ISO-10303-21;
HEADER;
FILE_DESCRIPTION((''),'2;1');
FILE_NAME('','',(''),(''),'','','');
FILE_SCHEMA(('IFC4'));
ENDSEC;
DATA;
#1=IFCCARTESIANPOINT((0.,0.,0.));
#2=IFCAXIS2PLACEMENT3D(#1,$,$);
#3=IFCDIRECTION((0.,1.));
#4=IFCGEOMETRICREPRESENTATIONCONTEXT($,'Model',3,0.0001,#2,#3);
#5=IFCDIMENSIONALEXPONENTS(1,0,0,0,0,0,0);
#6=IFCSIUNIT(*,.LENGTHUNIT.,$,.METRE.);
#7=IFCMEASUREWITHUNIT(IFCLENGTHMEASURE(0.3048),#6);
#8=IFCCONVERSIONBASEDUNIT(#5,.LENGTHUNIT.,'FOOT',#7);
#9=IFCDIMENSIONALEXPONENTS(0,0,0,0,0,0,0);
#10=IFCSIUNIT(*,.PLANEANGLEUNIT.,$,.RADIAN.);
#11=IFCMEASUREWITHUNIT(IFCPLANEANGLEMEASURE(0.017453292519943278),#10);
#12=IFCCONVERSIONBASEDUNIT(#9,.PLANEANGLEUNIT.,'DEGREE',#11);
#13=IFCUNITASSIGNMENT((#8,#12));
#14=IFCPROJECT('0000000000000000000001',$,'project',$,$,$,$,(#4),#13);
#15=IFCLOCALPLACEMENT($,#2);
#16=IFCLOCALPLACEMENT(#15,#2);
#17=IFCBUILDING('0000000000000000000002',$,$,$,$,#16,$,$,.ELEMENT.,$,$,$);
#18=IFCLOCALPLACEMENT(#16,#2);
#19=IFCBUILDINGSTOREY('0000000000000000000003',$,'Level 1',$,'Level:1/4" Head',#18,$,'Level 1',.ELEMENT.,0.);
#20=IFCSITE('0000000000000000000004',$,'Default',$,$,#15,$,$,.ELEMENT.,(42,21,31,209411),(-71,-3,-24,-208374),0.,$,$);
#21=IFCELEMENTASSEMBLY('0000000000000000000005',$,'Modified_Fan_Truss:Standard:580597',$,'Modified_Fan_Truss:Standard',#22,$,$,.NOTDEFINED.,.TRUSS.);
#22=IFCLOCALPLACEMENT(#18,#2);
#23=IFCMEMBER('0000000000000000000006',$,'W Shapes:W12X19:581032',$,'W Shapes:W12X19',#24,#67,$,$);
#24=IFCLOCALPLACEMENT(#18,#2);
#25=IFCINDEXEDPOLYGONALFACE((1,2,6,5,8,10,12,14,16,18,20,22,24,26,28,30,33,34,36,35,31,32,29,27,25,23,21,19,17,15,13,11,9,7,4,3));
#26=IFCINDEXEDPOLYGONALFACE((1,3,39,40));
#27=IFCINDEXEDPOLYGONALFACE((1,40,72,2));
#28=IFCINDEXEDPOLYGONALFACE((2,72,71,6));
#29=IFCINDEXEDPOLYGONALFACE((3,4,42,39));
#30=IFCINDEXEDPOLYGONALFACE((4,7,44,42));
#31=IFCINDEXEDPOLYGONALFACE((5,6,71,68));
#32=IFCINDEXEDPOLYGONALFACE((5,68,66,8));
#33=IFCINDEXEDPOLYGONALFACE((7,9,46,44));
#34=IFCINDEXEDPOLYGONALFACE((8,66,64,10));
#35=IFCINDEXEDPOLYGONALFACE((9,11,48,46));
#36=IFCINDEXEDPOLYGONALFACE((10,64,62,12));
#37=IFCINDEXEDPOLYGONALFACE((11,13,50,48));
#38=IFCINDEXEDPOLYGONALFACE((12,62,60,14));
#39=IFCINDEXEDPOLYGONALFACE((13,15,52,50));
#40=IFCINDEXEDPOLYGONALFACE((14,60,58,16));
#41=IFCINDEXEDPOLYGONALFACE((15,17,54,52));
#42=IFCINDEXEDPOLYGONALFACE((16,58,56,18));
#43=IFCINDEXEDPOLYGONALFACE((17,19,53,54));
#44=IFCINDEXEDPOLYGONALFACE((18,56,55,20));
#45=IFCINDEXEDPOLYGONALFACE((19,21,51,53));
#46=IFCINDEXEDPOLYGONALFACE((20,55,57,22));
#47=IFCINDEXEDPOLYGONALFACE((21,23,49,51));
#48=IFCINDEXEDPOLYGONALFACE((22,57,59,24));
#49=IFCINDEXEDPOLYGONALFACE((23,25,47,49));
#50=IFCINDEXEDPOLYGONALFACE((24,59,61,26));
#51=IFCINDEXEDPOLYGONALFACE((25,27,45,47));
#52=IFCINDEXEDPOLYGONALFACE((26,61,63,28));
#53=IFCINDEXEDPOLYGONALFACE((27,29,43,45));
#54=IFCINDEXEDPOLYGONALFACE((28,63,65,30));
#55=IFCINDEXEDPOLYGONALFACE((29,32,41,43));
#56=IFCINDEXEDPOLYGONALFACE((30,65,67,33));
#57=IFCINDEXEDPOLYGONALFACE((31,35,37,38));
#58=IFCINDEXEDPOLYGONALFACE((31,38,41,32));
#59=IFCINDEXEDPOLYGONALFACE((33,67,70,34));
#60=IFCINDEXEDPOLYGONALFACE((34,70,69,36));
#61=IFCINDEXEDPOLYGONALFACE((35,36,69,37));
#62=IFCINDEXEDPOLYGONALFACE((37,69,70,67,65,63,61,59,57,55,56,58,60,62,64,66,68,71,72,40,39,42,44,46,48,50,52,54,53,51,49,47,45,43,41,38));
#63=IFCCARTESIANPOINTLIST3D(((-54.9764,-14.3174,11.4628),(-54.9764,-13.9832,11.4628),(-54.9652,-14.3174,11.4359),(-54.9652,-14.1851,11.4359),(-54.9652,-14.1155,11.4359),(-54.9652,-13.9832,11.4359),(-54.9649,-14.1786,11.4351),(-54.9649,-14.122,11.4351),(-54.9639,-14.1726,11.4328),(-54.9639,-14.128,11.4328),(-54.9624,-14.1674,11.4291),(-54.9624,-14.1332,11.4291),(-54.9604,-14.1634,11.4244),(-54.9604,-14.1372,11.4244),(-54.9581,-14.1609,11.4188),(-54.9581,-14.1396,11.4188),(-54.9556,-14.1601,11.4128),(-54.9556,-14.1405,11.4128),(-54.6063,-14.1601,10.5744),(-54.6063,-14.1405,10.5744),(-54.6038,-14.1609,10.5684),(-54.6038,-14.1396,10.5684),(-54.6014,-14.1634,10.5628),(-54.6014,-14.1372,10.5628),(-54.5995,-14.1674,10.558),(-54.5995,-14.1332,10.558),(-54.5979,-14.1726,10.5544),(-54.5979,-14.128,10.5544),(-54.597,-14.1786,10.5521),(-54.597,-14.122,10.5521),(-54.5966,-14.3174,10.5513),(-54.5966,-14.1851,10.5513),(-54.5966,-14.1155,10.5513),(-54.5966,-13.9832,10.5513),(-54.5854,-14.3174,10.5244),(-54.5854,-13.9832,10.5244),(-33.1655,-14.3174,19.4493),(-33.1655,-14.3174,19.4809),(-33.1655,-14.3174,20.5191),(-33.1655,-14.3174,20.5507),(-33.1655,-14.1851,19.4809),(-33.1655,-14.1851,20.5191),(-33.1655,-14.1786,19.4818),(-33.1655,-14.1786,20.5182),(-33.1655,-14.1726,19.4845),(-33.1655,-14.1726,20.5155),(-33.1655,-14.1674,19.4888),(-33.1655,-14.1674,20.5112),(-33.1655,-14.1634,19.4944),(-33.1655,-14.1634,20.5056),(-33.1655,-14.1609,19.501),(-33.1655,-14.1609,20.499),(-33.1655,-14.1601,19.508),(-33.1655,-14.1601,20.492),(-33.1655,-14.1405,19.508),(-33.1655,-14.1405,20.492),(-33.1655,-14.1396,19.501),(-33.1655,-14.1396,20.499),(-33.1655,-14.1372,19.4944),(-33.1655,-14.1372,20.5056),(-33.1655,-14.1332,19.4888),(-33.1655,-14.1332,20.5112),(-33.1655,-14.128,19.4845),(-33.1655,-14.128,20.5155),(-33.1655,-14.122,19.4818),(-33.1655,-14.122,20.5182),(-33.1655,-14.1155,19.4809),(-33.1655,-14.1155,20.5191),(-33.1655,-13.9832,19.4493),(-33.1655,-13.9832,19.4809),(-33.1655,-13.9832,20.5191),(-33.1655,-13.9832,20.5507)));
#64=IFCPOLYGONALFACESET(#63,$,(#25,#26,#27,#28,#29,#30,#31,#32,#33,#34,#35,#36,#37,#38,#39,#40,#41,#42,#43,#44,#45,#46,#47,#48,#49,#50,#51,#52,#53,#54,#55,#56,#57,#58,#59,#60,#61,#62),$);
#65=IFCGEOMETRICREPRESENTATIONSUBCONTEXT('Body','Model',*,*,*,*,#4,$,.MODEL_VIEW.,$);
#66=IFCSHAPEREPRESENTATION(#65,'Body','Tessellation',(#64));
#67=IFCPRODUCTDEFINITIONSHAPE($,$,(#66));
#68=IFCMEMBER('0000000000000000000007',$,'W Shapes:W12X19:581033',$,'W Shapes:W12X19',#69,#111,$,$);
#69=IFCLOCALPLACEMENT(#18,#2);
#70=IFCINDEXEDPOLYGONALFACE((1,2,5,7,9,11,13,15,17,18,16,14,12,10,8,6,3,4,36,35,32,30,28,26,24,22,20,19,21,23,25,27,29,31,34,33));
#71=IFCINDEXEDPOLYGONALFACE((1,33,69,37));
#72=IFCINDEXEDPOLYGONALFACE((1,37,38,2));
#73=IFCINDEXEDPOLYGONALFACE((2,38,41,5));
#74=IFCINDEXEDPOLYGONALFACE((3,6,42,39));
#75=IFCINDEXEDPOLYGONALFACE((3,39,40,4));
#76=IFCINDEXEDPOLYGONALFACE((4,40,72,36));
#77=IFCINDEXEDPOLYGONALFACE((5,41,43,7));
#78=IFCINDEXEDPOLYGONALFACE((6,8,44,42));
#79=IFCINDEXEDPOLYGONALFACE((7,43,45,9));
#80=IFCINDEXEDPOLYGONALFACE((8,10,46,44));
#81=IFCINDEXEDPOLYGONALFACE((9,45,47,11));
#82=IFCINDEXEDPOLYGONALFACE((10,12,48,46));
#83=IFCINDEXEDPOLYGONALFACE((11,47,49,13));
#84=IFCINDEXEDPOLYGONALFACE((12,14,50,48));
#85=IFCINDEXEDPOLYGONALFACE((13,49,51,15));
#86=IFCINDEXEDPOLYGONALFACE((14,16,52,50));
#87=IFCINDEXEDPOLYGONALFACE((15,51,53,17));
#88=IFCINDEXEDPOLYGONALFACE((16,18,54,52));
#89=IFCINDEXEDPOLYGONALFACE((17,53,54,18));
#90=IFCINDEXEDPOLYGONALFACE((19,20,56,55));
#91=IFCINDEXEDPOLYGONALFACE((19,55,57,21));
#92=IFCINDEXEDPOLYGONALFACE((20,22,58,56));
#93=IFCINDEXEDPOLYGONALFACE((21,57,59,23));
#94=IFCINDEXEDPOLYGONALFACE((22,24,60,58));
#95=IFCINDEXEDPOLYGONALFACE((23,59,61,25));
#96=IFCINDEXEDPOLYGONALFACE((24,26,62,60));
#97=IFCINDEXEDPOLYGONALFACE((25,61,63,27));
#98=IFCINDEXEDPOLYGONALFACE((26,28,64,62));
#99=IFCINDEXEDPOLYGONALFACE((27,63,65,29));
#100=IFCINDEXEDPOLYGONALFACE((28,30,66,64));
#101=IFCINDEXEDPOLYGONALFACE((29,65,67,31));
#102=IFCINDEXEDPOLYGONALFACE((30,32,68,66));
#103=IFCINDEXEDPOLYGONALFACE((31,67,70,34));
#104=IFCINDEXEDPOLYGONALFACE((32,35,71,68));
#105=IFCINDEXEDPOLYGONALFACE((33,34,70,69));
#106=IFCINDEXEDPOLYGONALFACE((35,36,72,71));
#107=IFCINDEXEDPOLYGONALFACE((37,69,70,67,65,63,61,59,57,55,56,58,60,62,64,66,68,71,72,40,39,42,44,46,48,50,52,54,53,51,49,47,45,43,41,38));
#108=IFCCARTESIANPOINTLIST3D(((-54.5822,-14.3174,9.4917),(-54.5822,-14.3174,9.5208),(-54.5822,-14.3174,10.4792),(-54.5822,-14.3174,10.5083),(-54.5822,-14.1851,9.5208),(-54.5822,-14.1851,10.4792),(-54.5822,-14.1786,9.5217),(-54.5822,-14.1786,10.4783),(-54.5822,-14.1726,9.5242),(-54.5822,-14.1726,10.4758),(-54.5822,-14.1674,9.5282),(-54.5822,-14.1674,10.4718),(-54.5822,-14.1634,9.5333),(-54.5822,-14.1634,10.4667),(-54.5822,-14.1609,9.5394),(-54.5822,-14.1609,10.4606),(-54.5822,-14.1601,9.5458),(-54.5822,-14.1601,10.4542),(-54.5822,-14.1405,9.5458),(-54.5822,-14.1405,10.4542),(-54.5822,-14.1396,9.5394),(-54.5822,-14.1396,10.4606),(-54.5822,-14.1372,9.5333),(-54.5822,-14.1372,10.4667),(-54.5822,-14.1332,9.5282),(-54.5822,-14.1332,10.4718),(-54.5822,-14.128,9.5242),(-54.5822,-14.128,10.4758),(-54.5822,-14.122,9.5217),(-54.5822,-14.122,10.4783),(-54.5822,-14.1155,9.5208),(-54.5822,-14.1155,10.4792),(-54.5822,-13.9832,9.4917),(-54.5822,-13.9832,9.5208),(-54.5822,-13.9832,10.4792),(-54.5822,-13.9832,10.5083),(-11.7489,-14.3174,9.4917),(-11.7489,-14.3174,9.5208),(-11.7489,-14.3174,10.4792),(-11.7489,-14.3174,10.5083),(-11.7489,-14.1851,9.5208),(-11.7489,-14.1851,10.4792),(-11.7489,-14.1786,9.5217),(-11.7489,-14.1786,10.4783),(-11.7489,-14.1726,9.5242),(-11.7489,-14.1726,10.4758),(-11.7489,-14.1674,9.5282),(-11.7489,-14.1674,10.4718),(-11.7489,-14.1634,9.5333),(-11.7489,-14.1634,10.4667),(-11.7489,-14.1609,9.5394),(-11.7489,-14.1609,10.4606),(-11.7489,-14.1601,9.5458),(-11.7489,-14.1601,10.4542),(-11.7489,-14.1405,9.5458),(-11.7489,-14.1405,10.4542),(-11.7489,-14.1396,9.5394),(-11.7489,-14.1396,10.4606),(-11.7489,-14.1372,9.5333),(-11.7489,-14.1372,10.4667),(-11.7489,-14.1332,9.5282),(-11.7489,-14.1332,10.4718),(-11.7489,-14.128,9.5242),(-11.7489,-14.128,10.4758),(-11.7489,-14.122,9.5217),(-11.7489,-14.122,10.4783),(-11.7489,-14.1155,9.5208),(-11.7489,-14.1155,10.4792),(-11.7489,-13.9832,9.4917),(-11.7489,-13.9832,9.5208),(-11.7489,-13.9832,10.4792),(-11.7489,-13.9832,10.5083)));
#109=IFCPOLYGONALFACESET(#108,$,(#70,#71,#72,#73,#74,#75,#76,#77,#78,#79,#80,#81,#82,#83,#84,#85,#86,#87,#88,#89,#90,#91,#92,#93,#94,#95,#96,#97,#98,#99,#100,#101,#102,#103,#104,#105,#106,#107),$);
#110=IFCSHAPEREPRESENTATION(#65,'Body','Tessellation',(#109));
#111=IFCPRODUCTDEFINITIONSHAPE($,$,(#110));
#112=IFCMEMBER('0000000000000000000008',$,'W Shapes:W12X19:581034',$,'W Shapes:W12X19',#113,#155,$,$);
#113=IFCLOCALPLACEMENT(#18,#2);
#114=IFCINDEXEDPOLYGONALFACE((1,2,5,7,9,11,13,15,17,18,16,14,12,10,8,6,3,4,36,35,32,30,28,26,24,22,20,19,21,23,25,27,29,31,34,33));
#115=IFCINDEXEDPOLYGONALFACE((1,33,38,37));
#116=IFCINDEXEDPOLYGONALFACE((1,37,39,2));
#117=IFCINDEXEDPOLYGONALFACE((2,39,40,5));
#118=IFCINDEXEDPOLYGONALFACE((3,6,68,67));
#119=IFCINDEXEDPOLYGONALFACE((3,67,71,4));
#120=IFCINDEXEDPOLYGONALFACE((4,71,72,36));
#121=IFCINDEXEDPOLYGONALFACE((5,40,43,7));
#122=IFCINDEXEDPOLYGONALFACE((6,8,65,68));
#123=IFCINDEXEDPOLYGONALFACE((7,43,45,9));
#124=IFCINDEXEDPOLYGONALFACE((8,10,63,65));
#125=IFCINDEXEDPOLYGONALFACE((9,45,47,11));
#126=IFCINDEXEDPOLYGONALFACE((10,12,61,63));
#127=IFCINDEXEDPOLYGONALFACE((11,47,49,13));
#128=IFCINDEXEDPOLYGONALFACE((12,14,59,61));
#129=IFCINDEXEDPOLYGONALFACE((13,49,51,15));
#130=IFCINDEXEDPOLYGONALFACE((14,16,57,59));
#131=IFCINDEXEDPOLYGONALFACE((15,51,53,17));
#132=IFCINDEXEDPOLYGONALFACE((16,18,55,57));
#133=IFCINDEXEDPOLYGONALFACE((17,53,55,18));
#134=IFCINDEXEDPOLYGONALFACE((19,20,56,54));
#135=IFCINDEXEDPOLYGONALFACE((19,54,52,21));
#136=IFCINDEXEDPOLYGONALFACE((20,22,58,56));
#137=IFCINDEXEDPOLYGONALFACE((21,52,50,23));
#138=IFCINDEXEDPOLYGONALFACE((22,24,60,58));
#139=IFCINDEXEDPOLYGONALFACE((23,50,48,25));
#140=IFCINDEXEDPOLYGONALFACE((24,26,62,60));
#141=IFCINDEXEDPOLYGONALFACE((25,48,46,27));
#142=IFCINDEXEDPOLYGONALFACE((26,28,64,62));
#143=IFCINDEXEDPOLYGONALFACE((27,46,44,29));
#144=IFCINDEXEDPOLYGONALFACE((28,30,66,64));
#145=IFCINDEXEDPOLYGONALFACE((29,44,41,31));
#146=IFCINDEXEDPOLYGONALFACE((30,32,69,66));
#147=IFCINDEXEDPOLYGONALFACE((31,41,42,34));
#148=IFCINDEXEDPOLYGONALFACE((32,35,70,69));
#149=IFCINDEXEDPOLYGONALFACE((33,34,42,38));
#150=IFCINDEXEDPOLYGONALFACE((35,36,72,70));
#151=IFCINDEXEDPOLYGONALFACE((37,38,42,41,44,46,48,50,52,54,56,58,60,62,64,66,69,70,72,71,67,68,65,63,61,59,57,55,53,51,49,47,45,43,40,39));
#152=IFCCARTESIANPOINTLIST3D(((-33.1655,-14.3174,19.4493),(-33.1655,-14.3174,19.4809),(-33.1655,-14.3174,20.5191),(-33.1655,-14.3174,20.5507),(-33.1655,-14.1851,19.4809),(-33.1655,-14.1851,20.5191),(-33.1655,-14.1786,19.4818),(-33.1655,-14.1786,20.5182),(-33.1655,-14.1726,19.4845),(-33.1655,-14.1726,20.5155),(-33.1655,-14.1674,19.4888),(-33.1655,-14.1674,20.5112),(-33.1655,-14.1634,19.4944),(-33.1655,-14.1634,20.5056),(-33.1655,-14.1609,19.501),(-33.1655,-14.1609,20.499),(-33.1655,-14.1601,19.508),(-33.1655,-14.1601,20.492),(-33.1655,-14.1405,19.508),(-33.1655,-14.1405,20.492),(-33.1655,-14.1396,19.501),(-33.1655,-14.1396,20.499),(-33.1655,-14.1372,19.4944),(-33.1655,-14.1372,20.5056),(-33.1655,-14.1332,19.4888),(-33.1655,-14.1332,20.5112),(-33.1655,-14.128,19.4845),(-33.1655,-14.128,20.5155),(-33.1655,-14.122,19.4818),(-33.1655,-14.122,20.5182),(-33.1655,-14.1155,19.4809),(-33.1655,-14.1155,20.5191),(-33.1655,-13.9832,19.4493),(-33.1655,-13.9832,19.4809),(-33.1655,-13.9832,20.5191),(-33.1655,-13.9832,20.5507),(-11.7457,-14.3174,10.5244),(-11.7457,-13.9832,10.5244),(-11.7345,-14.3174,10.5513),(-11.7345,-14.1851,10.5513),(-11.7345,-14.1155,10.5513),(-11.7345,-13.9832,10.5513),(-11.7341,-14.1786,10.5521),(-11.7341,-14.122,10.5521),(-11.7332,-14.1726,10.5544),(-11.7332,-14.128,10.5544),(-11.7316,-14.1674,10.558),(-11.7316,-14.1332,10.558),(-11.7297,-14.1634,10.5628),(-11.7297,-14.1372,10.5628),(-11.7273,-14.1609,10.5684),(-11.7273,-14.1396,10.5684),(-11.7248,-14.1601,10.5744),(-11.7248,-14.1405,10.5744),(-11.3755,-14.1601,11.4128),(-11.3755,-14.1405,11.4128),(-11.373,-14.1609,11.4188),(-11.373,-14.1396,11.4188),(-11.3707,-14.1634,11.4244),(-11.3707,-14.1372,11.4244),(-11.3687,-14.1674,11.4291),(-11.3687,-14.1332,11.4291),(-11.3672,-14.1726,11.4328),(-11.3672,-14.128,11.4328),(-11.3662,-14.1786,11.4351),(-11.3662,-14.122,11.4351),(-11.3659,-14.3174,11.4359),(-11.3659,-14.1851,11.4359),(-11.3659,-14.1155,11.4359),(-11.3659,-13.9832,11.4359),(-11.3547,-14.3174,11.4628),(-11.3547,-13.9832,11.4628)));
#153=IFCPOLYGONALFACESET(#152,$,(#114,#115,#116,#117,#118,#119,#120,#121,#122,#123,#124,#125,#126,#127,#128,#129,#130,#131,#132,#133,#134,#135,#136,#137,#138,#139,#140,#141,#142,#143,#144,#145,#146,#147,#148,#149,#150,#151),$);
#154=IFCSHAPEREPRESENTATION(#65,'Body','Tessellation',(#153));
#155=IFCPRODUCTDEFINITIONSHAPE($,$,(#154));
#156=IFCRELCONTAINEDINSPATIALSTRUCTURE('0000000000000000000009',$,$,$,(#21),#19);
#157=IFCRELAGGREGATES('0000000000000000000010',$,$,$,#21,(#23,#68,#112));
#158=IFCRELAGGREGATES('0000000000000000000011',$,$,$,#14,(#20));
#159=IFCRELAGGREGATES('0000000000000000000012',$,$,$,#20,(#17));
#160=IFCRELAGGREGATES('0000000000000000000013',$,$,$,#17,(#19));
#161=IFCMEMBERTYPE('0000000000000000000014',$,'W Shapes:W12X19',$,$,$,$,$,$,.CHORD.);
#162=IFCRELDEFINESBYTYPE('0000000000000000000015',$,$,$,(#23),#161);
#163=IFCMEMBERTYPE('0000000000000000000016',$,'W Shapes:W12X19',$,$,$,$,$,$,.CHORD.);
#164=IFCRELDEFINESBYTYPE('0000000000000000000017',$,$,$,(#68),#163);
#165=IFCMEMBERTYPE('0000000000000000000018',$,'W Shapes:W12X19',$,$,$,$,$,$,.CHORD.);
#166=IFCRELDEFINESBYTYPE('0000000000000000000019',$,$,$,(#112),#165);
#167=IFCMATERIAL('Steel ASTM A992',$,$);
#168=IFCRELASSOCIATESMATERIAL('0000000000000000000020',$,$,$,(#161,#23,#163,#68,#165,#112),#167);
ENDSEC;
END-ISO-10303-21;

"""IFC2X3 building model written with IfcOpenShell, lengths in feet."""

from ifc_helpers import new_model, entity, si_unit, converted_unit, direction, frame, frame_2d, origin, place, context, subcontext, project, spatial, polyline, circle_curve, parameter, trimmed, segment, composite_curve, i_section, outline, extrude, clip, halfspace, source, transform, mapped, material, type_object, type_shapes, element, aggregate, save


model = new_model("IFC2X3")

# Units and contexts
model_context = context("Model", 3, precision=0.0001, world=origin(), true_north=direction((0.0, 1.0)))
body_context = subcontext(model_context, "Body", "Model", "MODEL_VIEW")
ifc_project = project(units=[converted_unit("LENGTHUNIT", "FOOT", entity("IfcLengthMeasure", 0.3048), si_unit("LENGTHUNIT", "METRE"), dimensions=[1, 0, 0, 0, 0, 0, 0]), converted_unit("PLANEANGLEUNIT", "DEGREE", entity("IfcPlaneAngleMeasure", 0.017453292519943278), si_unit("PLANEANGLEUNIT", "RADIAN"), dimensions=[0, 0, 0, 0, 0, 0, 0])], contexts=[model_context])

# Site, building, storey
site_placement = place(None, origin())
site = spatial("IfcSite", under=ifc_project, at=site_placement, Name="Default", CompositionType="ELEMENT", RefLatitude=(42, 21, 31, 209411), RefLongitude=(-71, -3, -24, -208374), RefElevation=0.0)
building_placement = place(site_placement, origin())
building = spatial("IfcBuilding", under=site, at=building_placement, CompositionType="ELEMENT")
storey_placement = place(building_placement, origin())
storey = spatial("IfcBuildingStorey", under=building, at=storey_placement, Name="Level 1", ObjectType="Level:1/4\" Head", LongName="Level 1", CompositionType="ELEMENT", Elevation=0.0)

# Element assembly, members
assembly_placement = place(storey_placement, origin())
assembly = element("IfcElementAssembly", 1, at=assembly_placement, inside=storey, Name="Modified_Fan_Truss:Standard:580597", ObjectType="Modified_Fan_Truss:Standard", AssemblyPlace="NOTDEFINED", PredefinedType="TRUSS")
ifc_material = material(Name="Steel ASTM A992")
member_type_1 = type_object("IfcMemberType", Name="W Shapes:W12X19", PredefinedType="CHORD", material=ifc_material)
shared_shape_1 = source(origin(), body_context, "Body", "Clipping", [
    clip(extrude(i_section(OverallWidth=0.3342, OverallDepth=1.0167, WebThickness=0.0196, FlangeThickness=0.0292, FilletRadius=0.025, at=frame_2d((0.0, 0.0), x_axis=(1.0, 0.0))), frame((-54.7809, -14.1503, 10.9936), z_axis=(0.923077, 0.0, 0.384615), x_axis=(0.0, -1.0, 0.0)), (0.0, 0.0, 1.0), 23.6285), halfspace(frame((-33.1655, -14.1503, 20.5507), z_axis=(1.0, 0.0, 0.0), x_axis=(0.0, -1.0, 0.0)), False)),
])
type_shapes(member_type_1, [shared_shape_1])
member_1_placement = place(assembly_placement, origin())
member_1 = element("IfcMember", 2, at=member_1_placement, type_object=member_type_1, material=ifc_material, Name="W Shapes:W12X19:581032", ObjectType="W Shapes:W12X19", context=body_context, shape_type="MappedRepresentation", body=[
    mapped(shared_shape_1, transform((0.0, 0.0, 0.0), scale=1.0)),
])
member_type_2 = type_object("IfcMemberType", Name="W Shapes:W12X19", PredefinedType="CHORD", material=ifc_material)
shared_shape_2 = source(origin(), body_context, "Body", "SweptSolid", [
    extrude(outline(composite_curve([segment(polyline([(-0.1671, -0.4792), (-0.1671, -0.5083)]), True, "CONTINUOUS"), segment(polyline([(-0.1671, -0.5083), (0.1671, -0.5083)]), True, "CONTINUOUS"), segment(polyline([(0.1671, -0.5083), (0.1671, -0.4792)]), True, "CONTINUOUS"), segment(polyline([(0.1671, -0.4792), (0.0348, -0.4792)]), True, "CONTINUOUS"), segment(trimmed(circle_curve(frame_2d((0.0348, -0.4542), x_axis=(1.0, 0.0)), 0.025), [parameter(180.0)], [parameter(270.0)], True, "PARAMETER"), False, "CONTINUOUS"), segment(polyline([(0.0098, -0.4542), (0.0098, 0.4542)]), True, "CONTINUOUS"), segment(trimmed(circle_curve(frame_2d((0.0348, 0.4542), x_axis=(1.0, 0.0)), 0.025), [parameter(90.0)], [parameter(180.0)], True, "PARAMETER"), False, "CONTINUOUS"), segment(polyline([(0.0348, 0.4792), (0.1671, 0.4792)]), True, "CONTINUOUS"), segment(polyline([(0.1671, 0.4792), (0.1671, 0.5083)]), True, "CONTINUOUS"), segment(polyline([(0.1671, 0.5083), (-0.1671, 0.5083)]), True, "CONTINUOUS"), segment(polyline([(-0.1671, 0.5083), (-0.1671, 0.4792)]), True, "CONTINUOUS"), segment(polyline([(-0.1671, 0.4792), (-0.0348, 0.4792)]), True, "CONTINUOUS"), segment(trimmed(circle_curve(frame_2d((-0.0348, 0.4542), x_axis=(1.0, 0.0)), 0.025), [parameter(360.0)], [parameter(90.0)], True, "PARAMETER"), False, "CONTINUOUS"), segment(polyline([(-0.0098, 0.4542), (-0.0098, -0.4542)]), True, "CONTINUOUS"), segment(trimmed(circle_curve(frame_2d((-0.0348, -0.4542), x_axis=(1.0, 0.0)), 0.025), [parameter(270.0)], [parameter(360.0)], True, "PARAMETER"), False, "CONTINUOUS"), segment(polyline([(-0.0348, -0.4792), (-0.1671, -0.4792)]), True, "CONTINUOUS")], self_intersect=False)), frame((-21.4167, 0.0, 0.0), z_axis=(-1.0, 0.0, 0.0), x_axis=(0.0, -1.0, 0.0)), (0.0, 0.0, -1.0), 42.8333),
])
type_shapes(member_type_2, [shared_shape_2])
member_2_placement = place(assembly_placement, frame((-33.1655, -14.1503, 10.0)))
member_2 = element("IfcMember", 3, at=member_2_placement, type_object=member_type_2, material=ifc_material, Name="W Shapes:W12X19:581033", ObjectType="W Shapes:W12X19", context=body_context, shape_type="MappedRepresentation", body=[
    mapped(shared_shape_2, transform((0.0, 0.0, 0.0), scale=1.0)),
])
member_type_3 = type_object("IfcMemberType", Name="W Shapes:W12X19", PredefinedType="CHORD", material=ifc_material)
shared_shape_3 = source(origin(), body_context, "Body", "Clipping", [
    clip(extrude(i_section(OverallWidth=0.3342, OverallDepth=1.0167, WebThickness=0.0196, FlangeThickness=0.0292, FilletRadius=0.025, at=frame_2d((0.0, 0.0), x_axis=(1.0, 0.0))), frame((-33.3611, -14.1503, 20.0815), z_axis=(0.923077, 0.0, -0.384615), x_axis=(0.0, 1.0, 0.0)), (0.0, 0.0, 1.0), 23.6285), halfspace(frame((-33.1655, -14.1503, 20.5507), z_axis=(-1.0, 0.0, 0.0), x_axis=(0.0, 1.0, 0.0)), False)),
])
type_shapes(member_type_3, [shared_shape_3])
member_3_placement = place(assembly_placement, origin())
member_3 = element("IfcMember", 4, at=member_3_placement, type_object=member_type_3, material=ifc_material, Name="W Shapes:W12X19:581034", ObjectType="W Shapes:W12X19", context=body_context, shape_type="MappedRepresentation", body=[
    mapped(shared_shape_3, transform((0.0, 0.0, 0.0), scale=1.0)),
])
aggregate(assembly, [member_1, member_2, member_3])

save(model, "model.ifc")
